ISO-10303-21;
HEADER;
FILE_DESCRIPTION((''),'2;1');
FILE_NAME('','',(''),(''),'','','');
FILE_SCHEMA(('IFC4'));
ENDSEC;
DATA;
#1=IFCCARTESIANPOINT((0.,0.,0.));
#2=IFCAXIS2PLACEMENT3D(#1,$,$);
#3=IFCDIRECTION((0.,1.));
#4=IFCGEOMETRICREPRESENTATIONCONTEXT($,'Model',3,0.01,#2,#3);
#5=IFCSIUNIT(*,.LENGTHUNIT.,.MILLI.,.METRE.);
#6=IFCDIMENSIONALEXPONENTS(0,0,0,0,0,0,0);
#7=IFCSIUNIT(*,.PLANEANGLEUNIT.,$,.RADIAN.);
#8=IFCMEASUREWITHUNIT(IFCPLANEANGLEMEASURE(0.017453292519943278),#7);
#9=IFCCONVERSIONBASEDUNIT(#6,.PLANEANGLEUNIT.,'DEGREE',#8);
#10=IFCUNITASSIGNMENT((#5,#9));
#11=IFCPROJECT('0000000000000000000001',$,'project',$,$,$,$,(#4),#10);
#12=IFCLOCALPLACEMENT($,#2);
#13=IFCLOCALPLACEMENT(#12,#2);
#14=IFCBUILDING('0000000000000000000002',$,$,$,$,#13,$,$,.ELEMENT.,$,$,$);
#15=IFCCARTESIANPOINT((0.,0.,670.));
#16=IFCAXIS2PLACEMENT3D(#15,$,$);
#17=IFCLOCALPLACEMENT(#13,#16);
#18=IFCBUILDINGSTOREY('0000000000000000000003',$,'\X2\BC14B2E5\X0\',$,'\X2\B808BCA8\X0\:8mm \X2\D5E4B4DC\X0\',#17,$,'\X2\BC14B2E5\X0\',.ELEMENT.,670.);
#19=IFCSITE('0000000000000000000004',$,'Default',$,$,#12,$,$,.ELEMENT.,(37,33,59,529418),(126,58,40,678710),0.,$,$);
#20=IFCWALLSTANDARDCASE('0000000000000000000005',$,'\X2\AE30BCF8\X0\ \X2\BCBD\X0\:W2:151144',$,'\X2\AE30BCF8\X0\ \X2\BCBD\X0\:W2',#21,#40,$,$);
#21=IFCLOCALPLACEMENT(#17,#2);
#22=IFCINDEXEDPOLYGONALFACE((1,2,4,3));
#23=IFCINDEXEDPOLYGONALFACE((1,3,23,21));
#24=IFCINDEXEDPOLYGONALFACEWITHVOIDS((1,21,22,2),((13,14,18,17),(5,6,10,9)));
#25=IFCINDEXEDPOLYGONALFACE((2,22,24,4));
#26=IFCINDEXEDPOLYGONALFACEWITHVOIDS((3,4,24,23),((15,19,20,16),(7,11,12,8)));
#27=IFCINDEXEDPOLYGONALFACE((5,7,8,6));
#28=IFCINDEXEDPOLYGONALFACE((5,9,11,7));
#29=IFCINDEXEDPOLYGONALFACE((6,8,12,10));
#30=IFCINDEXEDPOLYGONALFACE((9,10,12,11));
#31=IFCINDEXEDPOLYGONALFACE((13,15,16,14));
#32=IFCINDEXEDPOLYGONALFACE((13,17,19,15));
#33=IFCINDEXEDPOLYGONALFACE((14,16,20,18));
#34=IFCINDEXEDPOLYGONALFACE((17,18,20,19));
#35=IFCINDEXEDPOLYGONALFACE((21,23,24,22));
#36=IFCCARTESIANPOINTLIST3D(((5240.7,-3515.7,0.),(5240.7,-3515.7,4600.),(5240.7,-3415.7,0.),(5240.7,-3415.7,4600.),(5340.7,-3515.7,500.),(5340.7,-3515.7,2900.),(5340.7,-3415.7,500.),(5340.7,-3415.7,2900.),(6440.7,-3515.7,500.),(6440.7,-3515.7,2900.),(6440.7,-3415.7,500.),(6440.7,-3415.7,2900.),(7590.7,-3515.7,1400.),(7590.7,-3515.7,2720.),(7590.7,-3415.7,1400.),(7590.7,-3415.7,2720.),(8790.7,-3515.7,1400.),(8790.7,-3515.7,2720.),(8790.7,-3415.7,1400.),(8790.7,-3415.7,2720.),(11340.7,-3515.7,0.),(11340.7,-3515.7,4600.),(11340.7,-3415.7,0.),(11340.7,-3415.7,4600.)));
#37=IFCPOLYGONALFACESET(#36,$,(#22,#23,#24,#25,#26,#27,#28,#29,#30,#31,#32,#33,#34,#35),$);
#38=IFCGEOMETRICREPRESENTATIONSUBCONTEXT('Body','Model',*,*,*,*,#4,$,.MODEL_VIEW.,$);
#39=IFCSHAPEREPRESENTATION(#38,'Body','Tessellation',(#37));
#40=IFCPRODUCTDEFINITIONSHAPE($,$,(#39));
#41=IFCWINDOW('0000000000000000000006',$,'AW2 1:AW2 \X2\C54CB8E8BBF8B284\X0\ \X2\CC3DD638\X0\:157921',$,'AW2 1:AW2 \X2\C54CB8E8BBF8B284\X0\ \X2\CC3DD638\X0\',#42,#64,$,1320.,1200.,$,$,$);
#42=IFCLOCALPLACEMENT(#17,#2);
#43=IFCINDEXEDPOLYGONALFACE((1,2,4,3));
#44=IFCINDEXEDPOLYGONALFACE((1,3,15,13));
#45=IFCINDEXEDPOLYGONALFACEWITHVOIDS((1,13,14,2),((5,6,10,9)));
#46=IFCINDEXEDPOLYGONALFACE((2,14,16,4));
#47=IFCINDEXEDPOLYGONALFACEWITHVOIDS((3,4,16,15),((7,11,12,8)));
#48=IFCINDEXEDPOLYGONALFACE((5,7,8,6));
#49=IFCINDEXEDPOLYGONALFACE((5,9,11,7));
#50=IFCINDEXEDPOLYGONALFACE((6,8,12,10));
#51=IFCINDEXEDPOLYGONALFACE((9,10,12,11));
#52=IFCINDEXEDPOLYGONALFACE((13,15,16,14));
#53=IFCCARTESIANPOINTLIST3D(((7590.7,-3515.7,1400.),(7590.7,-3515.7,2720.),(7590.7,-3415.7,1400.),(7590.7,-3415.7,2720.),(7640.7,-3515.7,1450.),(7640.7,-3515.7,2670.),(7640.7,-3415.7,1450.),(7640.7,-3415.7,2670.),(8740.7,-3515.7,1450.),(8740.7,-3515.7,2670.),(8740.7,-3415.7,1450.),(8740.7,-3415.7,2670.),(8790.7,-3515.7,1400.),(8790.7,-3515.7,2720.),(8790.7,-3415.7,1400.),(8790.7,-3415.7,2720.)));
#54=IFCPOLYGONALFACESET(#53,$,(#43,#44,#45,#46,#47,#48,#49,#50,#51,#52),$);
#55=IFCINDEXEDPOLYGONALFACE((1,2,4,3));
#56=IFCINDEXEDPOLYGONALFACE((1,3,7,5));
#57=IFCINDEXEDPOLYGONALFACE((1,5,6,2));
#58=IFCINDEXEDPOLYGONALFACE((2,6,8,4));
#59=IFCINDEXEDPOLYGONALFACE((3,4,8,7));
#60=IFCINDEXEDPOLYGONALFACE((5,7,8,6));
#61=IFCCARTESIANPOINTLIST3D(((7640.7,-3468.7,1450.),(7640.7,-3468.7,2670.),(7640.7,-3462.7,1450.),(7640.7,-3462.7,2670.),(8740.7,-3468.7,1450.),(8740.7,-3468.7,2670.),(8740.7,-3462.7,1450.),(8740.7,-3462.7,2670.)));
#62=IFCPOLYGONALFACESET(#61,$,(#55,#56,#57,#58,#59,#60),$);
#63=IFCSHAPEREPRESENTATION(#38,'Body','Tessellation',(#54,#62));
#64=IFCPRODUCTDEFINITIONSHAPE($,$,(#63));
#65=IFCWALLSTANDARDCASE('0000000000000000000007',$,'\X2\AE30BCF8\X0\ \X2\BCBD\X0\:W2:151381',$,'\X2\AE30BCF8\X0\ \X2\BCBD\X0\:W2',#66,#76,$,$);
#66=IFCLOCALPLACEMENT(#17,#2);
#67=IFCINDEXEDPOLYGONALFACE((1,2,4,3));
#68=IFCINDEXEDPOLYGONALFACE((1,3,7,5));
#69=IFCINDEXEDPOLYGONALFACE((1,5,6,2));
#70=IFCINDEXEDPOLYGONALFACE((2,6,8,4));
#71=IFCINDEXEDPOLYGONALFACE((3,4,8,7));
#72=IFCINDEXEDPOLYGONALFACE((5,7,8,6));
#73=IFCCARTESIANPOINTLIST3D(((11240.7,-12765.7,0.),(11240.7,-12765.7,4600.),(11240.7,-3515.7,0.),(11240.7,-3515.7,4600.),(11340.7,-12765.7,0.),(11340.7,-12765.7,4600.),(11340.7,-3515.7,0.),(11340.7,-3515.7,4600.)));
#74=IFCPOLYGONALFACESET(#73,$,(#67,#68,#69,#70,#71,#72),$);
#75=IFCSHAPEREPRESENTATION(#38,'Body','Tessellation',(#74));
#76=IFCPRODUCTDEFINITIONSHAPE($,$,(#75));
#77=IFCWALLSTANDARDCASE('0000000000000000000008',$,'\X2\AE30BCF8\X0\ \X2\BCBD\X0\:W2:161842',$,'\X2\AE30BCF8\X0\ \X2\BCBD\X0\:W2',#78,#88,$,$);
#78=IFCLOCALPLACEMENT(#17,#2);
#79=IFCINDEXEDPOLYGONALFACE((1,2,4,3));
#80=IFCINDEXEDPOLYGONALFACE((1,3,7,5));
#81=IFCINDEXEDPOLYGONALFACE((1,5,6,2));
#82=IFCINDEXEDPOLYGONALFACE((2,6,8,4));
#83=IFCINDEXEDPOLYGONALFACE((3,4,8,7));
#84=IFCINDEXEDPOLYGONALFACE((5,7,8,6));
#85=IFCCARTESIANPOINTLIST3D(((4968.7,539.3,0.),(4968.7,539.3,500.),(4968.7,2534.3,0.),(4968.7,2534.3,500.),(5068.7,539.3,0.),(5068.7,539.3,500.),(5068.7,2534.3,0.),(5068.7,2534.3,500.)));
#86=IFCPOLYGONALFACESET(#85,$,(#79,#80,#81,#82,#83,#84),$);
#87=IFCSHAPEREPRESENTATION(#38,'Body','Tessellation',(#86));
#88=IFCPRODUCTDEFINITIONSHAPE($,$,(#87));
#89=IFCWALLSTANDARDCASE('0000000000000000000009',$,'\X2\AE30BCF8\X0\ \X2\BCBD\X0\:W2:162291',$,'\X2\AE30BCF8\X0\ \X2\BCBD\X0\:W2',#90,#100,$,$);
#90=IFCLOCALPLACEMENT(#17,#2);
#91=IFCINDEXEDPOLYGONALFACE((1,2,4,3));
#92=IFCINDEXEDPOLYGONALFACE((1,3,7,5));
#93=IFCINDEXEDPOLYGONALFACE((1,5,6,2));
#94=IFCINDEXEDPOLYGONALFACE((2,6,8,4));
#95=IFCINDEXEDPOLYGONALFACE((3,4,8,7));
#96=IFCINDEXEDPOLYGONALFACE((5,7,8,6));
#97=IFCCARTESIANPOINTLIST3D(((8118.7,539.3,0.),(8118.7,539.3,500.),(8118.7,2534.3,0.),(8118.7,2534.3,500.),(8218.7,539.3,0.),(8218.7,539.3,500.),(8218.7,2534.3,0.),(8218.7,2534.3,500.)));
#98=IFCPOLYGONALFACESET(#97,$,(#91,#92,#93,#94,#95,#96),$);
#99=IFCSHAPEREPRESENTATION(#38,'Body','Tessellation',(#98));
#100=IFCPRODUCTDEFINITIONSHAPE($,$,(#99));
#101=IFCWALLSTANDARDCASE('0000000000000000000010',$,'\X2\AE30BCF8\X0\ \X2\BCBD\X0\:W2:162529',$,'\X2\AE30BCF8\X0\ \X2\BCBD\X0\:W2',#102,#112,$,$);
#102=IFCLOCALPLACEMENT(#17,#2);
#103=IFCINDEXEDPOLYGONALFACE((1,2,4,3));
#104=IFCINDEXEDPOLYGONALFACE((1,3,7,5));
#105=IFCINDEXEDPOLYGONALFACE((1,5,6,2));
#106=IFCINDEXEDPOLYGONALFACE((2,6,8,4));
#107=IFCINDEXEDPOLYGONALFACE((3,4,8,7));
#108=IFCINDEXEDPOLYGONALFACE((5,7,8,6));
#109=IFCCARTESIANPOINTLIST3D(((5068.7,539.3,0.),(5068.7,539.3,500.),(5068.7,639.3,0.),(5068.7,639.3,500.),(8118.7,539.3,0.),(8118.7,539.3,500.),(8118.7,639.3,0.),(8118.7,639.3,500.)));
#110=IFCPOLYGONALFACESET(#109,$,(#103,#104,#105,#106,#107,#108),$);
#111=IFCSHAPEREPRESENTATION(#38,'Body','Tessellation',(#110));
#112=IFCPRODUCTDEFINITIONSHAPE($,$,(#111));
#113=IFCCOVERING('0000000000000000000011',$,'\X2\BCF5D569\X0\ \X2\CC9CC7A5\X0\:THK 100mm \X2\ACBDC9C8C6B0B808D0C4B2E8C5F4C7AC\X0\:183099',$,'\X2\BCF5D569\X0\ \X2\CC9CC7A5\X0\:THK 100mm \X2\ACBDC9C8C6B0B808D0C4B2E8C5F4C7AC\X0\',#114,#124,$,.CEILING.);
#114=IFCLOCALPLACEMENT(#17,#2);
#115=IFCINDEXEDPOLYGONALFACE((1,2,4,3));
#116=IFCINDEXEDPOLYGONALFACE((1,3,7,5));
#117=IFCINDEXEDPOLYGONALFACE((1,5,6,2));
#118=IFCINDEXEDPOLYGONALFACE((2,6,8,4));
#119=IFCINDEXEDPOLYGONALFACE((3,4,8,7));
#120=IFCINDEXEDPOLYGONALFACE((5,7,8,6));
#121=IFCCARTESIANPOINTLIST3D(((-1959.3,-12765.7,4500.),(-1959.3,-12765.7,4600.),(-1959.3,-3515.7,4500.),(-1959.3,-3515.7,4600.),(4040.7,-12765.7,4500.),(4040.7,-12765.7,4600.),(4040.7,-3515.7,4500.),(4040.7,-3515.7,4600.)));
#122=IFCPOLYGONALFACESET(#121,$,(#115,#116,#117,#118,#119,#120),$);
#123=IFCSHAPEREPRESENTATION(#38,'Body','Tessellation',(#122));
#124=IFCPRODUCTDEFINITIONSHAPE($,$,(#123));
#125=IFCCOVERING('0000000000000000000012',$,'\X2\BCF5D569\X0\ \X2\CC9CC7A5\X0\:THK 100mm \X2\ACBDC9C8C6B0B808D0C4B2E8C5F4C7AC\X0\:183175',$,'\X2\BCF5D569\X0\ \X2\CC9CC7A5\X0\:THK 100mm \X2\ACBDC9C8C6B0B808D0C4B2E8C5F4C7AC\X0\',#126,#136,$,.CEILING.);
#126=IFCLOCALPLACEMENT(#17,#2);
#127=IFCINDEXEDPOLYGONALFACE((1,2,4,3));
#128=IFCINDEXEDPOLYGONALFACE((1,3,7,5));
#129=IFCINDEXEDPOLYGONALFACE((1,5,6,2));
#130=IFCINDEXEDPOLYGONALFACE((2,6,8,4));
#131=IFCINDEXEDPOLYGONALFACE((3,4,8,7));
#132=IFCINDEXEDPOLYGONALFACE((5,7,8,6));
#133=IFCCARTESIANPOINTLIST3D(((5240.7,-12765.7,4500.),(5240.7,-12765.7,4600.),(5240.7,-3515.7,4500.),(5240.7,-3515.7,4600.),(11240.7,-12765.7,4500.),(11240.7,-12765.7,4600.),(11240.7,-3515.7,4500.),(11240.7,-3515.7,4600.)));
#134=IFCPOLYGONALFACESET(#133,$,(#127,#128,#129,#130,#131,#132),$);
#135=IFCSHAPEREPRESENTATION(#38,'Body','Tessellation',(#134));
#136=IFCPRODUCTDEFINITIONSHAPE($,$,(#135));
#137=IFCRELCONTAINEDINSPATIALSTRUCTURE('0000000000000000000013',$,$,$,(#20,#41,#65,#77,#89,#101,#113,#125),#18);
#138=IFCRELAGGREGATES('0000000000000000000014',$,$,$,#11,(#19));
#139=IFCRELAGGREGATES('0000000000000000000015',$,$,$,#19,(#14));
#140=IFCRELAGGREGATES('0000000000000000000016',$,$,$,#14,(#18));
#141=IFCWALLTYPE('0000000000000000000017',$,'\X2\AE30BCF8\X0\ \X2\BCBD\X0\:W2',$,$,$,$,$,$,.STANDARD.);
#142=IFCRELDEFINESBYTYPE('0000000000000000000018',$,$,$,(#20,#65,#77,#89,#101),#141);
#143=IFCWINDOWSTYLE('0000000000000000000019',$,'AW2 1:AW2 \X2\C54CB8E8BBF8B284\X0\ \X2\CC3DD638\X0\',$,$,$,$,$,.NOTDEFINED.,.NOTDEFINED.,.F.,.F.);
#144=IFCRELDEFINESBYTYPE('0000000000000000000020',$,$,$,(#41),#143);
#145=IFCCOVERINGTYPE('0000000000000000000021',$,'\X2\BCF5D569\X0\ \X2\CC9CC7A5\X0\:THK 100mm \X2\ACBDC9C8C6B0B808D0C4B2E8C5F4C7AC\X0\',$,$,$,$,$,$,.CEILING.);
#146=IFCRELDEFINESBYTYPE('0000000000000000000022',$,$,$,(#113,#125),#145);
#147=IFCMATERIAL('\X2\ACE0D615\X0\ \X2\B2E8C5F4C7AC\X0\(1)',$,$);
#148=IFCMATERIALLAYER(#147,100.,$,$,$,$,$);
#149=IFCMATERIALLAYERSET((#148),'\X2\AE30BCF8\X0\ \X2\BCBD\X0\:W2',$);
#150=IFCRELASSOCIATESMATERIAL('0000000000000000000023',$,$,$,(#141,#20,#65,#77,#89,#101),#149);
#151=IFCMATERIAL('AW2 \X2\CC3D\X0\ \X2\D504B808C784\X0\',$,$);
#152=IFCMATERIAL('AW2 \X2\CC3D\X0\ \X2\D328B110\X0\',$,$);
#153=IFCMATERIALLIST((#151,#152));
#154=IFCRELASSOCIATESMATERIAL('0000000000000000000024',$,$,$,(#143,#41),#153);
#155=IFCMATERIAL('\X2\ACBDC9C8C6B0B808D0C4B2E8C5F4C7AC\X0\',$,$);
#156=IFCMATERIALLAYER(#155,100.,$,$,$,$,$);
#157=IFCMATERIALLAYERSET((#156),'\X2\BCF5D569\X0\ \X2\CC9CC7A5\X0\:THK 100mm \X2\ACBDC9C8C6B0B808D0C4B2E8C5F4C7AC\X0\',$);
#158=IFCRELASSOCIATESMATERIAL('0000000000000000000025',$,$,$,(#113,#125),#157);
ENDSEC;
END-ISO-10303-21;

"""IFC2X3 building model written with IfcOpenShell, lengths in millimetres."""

from ifc_helpers import new_model, entity, si_unit, converted_unit, direction, frame, frame_2d, origin, origin_2d_with_axis, place, context, subcontext, project, spatial, polyline, rectangle, outline, extrude, source, transform, mapped, material, material_list, layer, layer_set, layer_usage, type_object, type_shapes, element, fill, save


model = new_model("IFC2X3")

# Units and contexts
model_context = context("Model", 3, precision=0.01, world=origin(), true_north=direction((0.0, 1.0)))
body_context = subcontext(model_context, "Body", "Model", "MODEL_VIEW")
ifc_project = project(units=[si_unit("LENGTHUNIT", "METRE", prefix="MILLI"), converted_unit("PLANEANGLEUNIT", "DEGREE", entity("IfcPlaneAngleMeasure", 0.017453292519943278), si_unit("PLANEANGLEUNIT", "RADIAN"), dimensions=[0, 0, 0, 0, 0, 0, 0])], contexts=[model_context])

# Site, building, storey
site_placement = place(None, origin())
site = spatial("IfcSite", under=ifc_project, at=site_placement, Name="Default", CompositionType="ELEMENT", RefLatitude=(37, 33, 59, 529418), RefLongitude=(126, 58, 40, 678710), RefElevation=0.0)
building_placement = place(site_placement, origin())
building = spatial("IfcBuilding", under=site, at=building_placement, CompositionType="ELEMENT")
storey_placement = place(building_placement, frame((0.0, 0.0, 670.0)))
storey = spatial("IfcBuildingStorey", under=building, at=storey_placement, Name="바닥", ObjectType="레벨:8mm 헤드", LongName="바닥", CompositionType="ELEMENT", Elevation=670.0)

# Shared definitions
ifc_material_1 = material(Name="고형 단열재(1)")
ifc_layer_1 = layer(ifc_material_1, 100.0)
ifc_layer_set_1 = layer_set([ifc_layer_1], Name="기본 벽:W2")
wall_type_1 = type_object("IfcWallType", Name="기본 벽:W2", PredefinedType="STANDARD", material=ifc_layer_set_1)

# Shared definitions
ifc_material_2 = material(Name="AW2 창 프레임")
ifc_material_3 = material(Name="AW2 창 패널")
ifc_material_list = material_list([ifc_material_2, ifc_material_3])
window_style = type_object("IfcWindowStyle", Name="AW2 1:AW2 알루미늄 창호", ConstructionType="NOTDEFINED", OperationType="NOTDEFINED", ParameterTakesPrecedence=False, Sizeable=False, material=ifc_material_list)
shared_shape = source(origin(), body_context, "Body", "SweptSolid", [
    extrude(outline(polyline([(-600.0, -660.0), (600.0, -660.0), (600.0, 660.0), (-600.0, 660.0), (-600.0, -660.0)]), holes=[polyline([(-550.0, -610.0), (-550.0, 610.0), (550.0, 610.0), (550.0, -610.0), (-550.0, -610.0)])]), frame((600.0, 0.0, 660.0), z_axis=(0.0, 1.0, 0.0), x_axis=(1.0, 0.0, 0.0)), (0.0, 0.0, 1.0), 100.0),
    extrude(rectangle(XDim=6.0, YDim=1100.0, at=origin_2d_with_axis()), frame((600.0, 50.0, 50.0), z_axis=(0.0, 0.0, 1.0), x_axis=(0.0, -1.0, 0.0)), (0.0, 0.0, 1.0), 1220.0),
])
type_shapes(window_style, [shared_shape])

# Wall, openings, window
ifc_layer_usage_1 = layer_usage(ifc_layer_set_1, "AXIS2", "NEGATIVE", 50.0)
wall_1_placement = place(storey_placement, frame((5240.7, -3465.7, 0.0)))
wall_1 = element("IfcWallStandardCase", 1, at=wall_1_placement, inside=storey, type_object=wall_type_1, material=ifc_layer_usage_1, Name="기본 벽:W2:151144", ObjectType="기본 벽:W2", context=body_context, shape_type="SweptSolid", body=[
    extrude(rectangle(XDim=6100.0, YDim=100.0, at=frame_2d((3050.0, 0.0), x_axis=(-1.0, 0.0))), origin(), (0.0, 0.0, 1.0), 4600.0),
])
opening_1_placement = place(wall_1_placement, frame((100.0, -50.0, 500.0)))
element("IfcOpeningElement", 2, at=opening_1_placement, cuts=wall_1, ObjectType="Opening", context=body_context, shape_type="SweptSolid", body=[
    extrude(rectangle(XDim=2400.0, YDim=1100.0, at=frame_2d((1200.0, 550.0), x_axis=(1.0, 0.0))), frame((0.0, 0.0, 0.0), z_axis=(0.0, 1.0, 0.0), x_axis=(0.0, 0.0, 1.0)), (0.0, 0.0, 1.0), 100.0),
])
opening_2_placement = place(wall_1_placement, frame((3550.0, 50.0, 1400.0)))
opening_2 = element("IfcOpeningElement", 3, at=opening_2_placement, cuts=wall_1, ObjectType="Opening", context=body_context, shape_type="SweptSolid", body=[
    extrude(rectangle(XDim=1320.0, YDim=1200.0, at=frame_2d((660.0, 600.0), x_axis=(1.0, 0.0))), frame((0.0, 0.0, 0.0), z_axis=(0.0, -1.0, 0.0), x_axis=(0.0, 0.0, 1.0)), (0.0, 0.0, 1.0), 100.0),
])
window_1_placement = place(opening_2_placement, frame((0.0, 0.0, 0.0), z_axis=(0.0, 0.0, 1.0), x_axis=(-1.0, 0.0, 0.0)))
window_1 = element("IfcWindow", 4, at=window_1_placement, inside=storey, type_object=window_style, material=ifc_material_list, Name="AW2 1:AW2 알루미늄 창호:157921", ObjectType="AW2 1:AW2 알루미늄 창호", OverallHeight=1320.0, OverallWidth=1200.0, context=body_context, shape_type="MappedRepresentation", body=[
    mapped(shared_shape, transform((0.0, 0.0, 0.0), scale=1.0)),
])
fill(opening_2, window_1)

# Walls
ifc_layer_usage_2 = layer_usage(ifc_layer_set_1, "AXIS2", "NEGATIVE", 50.0)
wall_2_placement = place(storey_placement, frame((11290.7, -3515.7, 0.0), z_axis=(0.0, 0.0, 1.0), x_axis=(0.0, -1.0, 0.0)))
element("IfcWallStandardCase", 5, at=wall_2_placement, inside=storey, type_object=wall_type_1, material=ifc_layer_usage_2, Name="기본 벽:W2:151381", ObjectType="기본 벽:W2", context=body_context, shape_type="SweptSolid", body=[
    extrude(rectangle(XDim=9250.0, YDim=100.0, at=frame_2d((4625.0, 0.0), x_axis=(-1.0, 0.0))), origin(), (0.0, 0.0, 1.0), 4600.0),
])
ifc_layer_usage_3 = layer_usage(ifc_layer_set_1, "AXIS2", "NEGATIVE", 50.0)
wall_3_placement = place(storey_placement, frame((5018.7, 2534.3, 0.0), z_axis=(0.0, 0.0, 1.0), x_axis=(0.0, -1.0, 0.0)))
element("IfcWallStandardCase", 6, at=wall_3_placement, inside=storey, type_object=wall_type_1, material=ifc_layer_usage_3, Name="기본 벽:W2:161842", ObjectType="기본 벽:W2", context=body_context, shape_type="SweptSolid", body=[
    extrude(rectangle(XDim=1995.0, YDim=100.0, at=frame_2d((997.5, 0.0), x_axis=(-1.0, 0.0))), origin(), (0.0, 0.0, 1.0), 500.0),
])
ifc_layer_usage_4 = layer_usage(ifc_layer_set_1, "AXIS2", "NEGATIVE", 50.0)
wall_4_placement = place(storey_placement, frame((8168.7, 539.3, 0.0), z_axis=(0.0, 0.0, 1.0), x_axis=(0.0, 1.0, 0.0)))
element("IfcWallStandardCase", 7, at=wall_4_placement, inside=storey, type_object=wall_type_1, material=ifc_layer_usage_4, Name="기본 벽:W2:162291", ObjectType="기본 벽:W2", context=body_context, shape_type="SweptSolid", body=[
    extrude(rectangle(XDim=1995.0, YDim=100.0, at=frame_2d((997.5, 0.0), x_axis=(-1.0, 0.0))), origin(), (0.0, 0.0, 1.0), 500.0),
])
ifc_layer_usage_5 = layer_usage(ifc_layer_set_1, "AXIS2", "NEGATIVE", 50.0)
wall_5_placement = place(storey_placement, frame((5068.7, 589.3, 0.0)))
element("IfcWallStandardCase", 8, at=wall_5_placement, inside=storey, type_object=wall_type_1, material=ifc_layer_usage_5, Name="기본 벽:W2:162529", ObjectType="기본 벽:W2", context=body_context, shape_type="SweptSolid", body=[
    extrude(rectangle(XDim=3050.0, YDim=100.0, at=frame_2d((1525.0, 0.0), x_axis=(-1.0, 0.0))), origin(), (0.0, 0.0, 1.0), 500.0),
])

# Coverings
ifc_material_4 = material(Name="경질우레탄단열재")
ifc_layer_2 = layer(ifc_material_4, 100.0)
ifc_layer_set_2 = layer_set([ifc_layer_2], Name="복합 천장:THK 100mm 경질우레탄단열재")
ifc_layer_usage_6 = layer_usage(ifc_layer_set_2, "AXIS3", "NEGATIVE", 100.0)
covering_type = type_object("IfcCoveringType", Name="복합 천장:THK 100mm 경질우레탄단열재", PredefinedType="CEILING")
covering_1_placement = place(storey_placement, origin())
element("IfcCovering", 9, at=covering_1_placement, inside=storey, type_object=covering_type, material=ifc_layer_usage_6, Name="복합 천장:THK 100mm 경질우레탄단열재:183099", ObjectType="복합 천장:THK 100mm 경질우레탄단열재", PredefinedType="CEILING", context=body_context, shape_type="SweptSolid", body=[
    extrude(rectangle(XDim=9250.0, YDim=6000.0, at=frame_2d((0.0, 0.0), x_axis=(1.0, 0.0))), frame((1040.7, -8140.7, 4500.0), z_axis=(0.0, 0.0, 1.0), x_axis=(0.0, 1.0, 0.0)), (0.0, 0.0, 1.0), 100.0),
])
ifc_layer_usage_7 = layer_usage(ifc_layer_set_2, "AXIS3", "NEGATIVE", 100.0)
covering_2_placement = place(storey_placement, origin())
element("IfcCovering", 10, at=covering_2_placement, inside=storey, type_object=covering_type, material=ifc_layer_usage_7, Name="복합 천장:THK 100mm 경질우레탄단열재:183175", ObjectType="복합 천장:THK 100mm 경질우레탄단열재", PredefinedType="CEILING", context=body_context, shape_type="SweptSolid", body=[
    extrude(rectangle(XDim=9250.0, YDim=6000.0, at=frame_2d((0.0, 0.0), x_axis=(1.0, 0.0))), frame((8240.7, -8140.7, 4500.0), z_axis=(0.0, 0.0, 1.0), x_axis=(0.0, 1.0, 0.0)), (0.0, 0.0, 1.0), 100.0),
])

save(model, "model.ifc")
